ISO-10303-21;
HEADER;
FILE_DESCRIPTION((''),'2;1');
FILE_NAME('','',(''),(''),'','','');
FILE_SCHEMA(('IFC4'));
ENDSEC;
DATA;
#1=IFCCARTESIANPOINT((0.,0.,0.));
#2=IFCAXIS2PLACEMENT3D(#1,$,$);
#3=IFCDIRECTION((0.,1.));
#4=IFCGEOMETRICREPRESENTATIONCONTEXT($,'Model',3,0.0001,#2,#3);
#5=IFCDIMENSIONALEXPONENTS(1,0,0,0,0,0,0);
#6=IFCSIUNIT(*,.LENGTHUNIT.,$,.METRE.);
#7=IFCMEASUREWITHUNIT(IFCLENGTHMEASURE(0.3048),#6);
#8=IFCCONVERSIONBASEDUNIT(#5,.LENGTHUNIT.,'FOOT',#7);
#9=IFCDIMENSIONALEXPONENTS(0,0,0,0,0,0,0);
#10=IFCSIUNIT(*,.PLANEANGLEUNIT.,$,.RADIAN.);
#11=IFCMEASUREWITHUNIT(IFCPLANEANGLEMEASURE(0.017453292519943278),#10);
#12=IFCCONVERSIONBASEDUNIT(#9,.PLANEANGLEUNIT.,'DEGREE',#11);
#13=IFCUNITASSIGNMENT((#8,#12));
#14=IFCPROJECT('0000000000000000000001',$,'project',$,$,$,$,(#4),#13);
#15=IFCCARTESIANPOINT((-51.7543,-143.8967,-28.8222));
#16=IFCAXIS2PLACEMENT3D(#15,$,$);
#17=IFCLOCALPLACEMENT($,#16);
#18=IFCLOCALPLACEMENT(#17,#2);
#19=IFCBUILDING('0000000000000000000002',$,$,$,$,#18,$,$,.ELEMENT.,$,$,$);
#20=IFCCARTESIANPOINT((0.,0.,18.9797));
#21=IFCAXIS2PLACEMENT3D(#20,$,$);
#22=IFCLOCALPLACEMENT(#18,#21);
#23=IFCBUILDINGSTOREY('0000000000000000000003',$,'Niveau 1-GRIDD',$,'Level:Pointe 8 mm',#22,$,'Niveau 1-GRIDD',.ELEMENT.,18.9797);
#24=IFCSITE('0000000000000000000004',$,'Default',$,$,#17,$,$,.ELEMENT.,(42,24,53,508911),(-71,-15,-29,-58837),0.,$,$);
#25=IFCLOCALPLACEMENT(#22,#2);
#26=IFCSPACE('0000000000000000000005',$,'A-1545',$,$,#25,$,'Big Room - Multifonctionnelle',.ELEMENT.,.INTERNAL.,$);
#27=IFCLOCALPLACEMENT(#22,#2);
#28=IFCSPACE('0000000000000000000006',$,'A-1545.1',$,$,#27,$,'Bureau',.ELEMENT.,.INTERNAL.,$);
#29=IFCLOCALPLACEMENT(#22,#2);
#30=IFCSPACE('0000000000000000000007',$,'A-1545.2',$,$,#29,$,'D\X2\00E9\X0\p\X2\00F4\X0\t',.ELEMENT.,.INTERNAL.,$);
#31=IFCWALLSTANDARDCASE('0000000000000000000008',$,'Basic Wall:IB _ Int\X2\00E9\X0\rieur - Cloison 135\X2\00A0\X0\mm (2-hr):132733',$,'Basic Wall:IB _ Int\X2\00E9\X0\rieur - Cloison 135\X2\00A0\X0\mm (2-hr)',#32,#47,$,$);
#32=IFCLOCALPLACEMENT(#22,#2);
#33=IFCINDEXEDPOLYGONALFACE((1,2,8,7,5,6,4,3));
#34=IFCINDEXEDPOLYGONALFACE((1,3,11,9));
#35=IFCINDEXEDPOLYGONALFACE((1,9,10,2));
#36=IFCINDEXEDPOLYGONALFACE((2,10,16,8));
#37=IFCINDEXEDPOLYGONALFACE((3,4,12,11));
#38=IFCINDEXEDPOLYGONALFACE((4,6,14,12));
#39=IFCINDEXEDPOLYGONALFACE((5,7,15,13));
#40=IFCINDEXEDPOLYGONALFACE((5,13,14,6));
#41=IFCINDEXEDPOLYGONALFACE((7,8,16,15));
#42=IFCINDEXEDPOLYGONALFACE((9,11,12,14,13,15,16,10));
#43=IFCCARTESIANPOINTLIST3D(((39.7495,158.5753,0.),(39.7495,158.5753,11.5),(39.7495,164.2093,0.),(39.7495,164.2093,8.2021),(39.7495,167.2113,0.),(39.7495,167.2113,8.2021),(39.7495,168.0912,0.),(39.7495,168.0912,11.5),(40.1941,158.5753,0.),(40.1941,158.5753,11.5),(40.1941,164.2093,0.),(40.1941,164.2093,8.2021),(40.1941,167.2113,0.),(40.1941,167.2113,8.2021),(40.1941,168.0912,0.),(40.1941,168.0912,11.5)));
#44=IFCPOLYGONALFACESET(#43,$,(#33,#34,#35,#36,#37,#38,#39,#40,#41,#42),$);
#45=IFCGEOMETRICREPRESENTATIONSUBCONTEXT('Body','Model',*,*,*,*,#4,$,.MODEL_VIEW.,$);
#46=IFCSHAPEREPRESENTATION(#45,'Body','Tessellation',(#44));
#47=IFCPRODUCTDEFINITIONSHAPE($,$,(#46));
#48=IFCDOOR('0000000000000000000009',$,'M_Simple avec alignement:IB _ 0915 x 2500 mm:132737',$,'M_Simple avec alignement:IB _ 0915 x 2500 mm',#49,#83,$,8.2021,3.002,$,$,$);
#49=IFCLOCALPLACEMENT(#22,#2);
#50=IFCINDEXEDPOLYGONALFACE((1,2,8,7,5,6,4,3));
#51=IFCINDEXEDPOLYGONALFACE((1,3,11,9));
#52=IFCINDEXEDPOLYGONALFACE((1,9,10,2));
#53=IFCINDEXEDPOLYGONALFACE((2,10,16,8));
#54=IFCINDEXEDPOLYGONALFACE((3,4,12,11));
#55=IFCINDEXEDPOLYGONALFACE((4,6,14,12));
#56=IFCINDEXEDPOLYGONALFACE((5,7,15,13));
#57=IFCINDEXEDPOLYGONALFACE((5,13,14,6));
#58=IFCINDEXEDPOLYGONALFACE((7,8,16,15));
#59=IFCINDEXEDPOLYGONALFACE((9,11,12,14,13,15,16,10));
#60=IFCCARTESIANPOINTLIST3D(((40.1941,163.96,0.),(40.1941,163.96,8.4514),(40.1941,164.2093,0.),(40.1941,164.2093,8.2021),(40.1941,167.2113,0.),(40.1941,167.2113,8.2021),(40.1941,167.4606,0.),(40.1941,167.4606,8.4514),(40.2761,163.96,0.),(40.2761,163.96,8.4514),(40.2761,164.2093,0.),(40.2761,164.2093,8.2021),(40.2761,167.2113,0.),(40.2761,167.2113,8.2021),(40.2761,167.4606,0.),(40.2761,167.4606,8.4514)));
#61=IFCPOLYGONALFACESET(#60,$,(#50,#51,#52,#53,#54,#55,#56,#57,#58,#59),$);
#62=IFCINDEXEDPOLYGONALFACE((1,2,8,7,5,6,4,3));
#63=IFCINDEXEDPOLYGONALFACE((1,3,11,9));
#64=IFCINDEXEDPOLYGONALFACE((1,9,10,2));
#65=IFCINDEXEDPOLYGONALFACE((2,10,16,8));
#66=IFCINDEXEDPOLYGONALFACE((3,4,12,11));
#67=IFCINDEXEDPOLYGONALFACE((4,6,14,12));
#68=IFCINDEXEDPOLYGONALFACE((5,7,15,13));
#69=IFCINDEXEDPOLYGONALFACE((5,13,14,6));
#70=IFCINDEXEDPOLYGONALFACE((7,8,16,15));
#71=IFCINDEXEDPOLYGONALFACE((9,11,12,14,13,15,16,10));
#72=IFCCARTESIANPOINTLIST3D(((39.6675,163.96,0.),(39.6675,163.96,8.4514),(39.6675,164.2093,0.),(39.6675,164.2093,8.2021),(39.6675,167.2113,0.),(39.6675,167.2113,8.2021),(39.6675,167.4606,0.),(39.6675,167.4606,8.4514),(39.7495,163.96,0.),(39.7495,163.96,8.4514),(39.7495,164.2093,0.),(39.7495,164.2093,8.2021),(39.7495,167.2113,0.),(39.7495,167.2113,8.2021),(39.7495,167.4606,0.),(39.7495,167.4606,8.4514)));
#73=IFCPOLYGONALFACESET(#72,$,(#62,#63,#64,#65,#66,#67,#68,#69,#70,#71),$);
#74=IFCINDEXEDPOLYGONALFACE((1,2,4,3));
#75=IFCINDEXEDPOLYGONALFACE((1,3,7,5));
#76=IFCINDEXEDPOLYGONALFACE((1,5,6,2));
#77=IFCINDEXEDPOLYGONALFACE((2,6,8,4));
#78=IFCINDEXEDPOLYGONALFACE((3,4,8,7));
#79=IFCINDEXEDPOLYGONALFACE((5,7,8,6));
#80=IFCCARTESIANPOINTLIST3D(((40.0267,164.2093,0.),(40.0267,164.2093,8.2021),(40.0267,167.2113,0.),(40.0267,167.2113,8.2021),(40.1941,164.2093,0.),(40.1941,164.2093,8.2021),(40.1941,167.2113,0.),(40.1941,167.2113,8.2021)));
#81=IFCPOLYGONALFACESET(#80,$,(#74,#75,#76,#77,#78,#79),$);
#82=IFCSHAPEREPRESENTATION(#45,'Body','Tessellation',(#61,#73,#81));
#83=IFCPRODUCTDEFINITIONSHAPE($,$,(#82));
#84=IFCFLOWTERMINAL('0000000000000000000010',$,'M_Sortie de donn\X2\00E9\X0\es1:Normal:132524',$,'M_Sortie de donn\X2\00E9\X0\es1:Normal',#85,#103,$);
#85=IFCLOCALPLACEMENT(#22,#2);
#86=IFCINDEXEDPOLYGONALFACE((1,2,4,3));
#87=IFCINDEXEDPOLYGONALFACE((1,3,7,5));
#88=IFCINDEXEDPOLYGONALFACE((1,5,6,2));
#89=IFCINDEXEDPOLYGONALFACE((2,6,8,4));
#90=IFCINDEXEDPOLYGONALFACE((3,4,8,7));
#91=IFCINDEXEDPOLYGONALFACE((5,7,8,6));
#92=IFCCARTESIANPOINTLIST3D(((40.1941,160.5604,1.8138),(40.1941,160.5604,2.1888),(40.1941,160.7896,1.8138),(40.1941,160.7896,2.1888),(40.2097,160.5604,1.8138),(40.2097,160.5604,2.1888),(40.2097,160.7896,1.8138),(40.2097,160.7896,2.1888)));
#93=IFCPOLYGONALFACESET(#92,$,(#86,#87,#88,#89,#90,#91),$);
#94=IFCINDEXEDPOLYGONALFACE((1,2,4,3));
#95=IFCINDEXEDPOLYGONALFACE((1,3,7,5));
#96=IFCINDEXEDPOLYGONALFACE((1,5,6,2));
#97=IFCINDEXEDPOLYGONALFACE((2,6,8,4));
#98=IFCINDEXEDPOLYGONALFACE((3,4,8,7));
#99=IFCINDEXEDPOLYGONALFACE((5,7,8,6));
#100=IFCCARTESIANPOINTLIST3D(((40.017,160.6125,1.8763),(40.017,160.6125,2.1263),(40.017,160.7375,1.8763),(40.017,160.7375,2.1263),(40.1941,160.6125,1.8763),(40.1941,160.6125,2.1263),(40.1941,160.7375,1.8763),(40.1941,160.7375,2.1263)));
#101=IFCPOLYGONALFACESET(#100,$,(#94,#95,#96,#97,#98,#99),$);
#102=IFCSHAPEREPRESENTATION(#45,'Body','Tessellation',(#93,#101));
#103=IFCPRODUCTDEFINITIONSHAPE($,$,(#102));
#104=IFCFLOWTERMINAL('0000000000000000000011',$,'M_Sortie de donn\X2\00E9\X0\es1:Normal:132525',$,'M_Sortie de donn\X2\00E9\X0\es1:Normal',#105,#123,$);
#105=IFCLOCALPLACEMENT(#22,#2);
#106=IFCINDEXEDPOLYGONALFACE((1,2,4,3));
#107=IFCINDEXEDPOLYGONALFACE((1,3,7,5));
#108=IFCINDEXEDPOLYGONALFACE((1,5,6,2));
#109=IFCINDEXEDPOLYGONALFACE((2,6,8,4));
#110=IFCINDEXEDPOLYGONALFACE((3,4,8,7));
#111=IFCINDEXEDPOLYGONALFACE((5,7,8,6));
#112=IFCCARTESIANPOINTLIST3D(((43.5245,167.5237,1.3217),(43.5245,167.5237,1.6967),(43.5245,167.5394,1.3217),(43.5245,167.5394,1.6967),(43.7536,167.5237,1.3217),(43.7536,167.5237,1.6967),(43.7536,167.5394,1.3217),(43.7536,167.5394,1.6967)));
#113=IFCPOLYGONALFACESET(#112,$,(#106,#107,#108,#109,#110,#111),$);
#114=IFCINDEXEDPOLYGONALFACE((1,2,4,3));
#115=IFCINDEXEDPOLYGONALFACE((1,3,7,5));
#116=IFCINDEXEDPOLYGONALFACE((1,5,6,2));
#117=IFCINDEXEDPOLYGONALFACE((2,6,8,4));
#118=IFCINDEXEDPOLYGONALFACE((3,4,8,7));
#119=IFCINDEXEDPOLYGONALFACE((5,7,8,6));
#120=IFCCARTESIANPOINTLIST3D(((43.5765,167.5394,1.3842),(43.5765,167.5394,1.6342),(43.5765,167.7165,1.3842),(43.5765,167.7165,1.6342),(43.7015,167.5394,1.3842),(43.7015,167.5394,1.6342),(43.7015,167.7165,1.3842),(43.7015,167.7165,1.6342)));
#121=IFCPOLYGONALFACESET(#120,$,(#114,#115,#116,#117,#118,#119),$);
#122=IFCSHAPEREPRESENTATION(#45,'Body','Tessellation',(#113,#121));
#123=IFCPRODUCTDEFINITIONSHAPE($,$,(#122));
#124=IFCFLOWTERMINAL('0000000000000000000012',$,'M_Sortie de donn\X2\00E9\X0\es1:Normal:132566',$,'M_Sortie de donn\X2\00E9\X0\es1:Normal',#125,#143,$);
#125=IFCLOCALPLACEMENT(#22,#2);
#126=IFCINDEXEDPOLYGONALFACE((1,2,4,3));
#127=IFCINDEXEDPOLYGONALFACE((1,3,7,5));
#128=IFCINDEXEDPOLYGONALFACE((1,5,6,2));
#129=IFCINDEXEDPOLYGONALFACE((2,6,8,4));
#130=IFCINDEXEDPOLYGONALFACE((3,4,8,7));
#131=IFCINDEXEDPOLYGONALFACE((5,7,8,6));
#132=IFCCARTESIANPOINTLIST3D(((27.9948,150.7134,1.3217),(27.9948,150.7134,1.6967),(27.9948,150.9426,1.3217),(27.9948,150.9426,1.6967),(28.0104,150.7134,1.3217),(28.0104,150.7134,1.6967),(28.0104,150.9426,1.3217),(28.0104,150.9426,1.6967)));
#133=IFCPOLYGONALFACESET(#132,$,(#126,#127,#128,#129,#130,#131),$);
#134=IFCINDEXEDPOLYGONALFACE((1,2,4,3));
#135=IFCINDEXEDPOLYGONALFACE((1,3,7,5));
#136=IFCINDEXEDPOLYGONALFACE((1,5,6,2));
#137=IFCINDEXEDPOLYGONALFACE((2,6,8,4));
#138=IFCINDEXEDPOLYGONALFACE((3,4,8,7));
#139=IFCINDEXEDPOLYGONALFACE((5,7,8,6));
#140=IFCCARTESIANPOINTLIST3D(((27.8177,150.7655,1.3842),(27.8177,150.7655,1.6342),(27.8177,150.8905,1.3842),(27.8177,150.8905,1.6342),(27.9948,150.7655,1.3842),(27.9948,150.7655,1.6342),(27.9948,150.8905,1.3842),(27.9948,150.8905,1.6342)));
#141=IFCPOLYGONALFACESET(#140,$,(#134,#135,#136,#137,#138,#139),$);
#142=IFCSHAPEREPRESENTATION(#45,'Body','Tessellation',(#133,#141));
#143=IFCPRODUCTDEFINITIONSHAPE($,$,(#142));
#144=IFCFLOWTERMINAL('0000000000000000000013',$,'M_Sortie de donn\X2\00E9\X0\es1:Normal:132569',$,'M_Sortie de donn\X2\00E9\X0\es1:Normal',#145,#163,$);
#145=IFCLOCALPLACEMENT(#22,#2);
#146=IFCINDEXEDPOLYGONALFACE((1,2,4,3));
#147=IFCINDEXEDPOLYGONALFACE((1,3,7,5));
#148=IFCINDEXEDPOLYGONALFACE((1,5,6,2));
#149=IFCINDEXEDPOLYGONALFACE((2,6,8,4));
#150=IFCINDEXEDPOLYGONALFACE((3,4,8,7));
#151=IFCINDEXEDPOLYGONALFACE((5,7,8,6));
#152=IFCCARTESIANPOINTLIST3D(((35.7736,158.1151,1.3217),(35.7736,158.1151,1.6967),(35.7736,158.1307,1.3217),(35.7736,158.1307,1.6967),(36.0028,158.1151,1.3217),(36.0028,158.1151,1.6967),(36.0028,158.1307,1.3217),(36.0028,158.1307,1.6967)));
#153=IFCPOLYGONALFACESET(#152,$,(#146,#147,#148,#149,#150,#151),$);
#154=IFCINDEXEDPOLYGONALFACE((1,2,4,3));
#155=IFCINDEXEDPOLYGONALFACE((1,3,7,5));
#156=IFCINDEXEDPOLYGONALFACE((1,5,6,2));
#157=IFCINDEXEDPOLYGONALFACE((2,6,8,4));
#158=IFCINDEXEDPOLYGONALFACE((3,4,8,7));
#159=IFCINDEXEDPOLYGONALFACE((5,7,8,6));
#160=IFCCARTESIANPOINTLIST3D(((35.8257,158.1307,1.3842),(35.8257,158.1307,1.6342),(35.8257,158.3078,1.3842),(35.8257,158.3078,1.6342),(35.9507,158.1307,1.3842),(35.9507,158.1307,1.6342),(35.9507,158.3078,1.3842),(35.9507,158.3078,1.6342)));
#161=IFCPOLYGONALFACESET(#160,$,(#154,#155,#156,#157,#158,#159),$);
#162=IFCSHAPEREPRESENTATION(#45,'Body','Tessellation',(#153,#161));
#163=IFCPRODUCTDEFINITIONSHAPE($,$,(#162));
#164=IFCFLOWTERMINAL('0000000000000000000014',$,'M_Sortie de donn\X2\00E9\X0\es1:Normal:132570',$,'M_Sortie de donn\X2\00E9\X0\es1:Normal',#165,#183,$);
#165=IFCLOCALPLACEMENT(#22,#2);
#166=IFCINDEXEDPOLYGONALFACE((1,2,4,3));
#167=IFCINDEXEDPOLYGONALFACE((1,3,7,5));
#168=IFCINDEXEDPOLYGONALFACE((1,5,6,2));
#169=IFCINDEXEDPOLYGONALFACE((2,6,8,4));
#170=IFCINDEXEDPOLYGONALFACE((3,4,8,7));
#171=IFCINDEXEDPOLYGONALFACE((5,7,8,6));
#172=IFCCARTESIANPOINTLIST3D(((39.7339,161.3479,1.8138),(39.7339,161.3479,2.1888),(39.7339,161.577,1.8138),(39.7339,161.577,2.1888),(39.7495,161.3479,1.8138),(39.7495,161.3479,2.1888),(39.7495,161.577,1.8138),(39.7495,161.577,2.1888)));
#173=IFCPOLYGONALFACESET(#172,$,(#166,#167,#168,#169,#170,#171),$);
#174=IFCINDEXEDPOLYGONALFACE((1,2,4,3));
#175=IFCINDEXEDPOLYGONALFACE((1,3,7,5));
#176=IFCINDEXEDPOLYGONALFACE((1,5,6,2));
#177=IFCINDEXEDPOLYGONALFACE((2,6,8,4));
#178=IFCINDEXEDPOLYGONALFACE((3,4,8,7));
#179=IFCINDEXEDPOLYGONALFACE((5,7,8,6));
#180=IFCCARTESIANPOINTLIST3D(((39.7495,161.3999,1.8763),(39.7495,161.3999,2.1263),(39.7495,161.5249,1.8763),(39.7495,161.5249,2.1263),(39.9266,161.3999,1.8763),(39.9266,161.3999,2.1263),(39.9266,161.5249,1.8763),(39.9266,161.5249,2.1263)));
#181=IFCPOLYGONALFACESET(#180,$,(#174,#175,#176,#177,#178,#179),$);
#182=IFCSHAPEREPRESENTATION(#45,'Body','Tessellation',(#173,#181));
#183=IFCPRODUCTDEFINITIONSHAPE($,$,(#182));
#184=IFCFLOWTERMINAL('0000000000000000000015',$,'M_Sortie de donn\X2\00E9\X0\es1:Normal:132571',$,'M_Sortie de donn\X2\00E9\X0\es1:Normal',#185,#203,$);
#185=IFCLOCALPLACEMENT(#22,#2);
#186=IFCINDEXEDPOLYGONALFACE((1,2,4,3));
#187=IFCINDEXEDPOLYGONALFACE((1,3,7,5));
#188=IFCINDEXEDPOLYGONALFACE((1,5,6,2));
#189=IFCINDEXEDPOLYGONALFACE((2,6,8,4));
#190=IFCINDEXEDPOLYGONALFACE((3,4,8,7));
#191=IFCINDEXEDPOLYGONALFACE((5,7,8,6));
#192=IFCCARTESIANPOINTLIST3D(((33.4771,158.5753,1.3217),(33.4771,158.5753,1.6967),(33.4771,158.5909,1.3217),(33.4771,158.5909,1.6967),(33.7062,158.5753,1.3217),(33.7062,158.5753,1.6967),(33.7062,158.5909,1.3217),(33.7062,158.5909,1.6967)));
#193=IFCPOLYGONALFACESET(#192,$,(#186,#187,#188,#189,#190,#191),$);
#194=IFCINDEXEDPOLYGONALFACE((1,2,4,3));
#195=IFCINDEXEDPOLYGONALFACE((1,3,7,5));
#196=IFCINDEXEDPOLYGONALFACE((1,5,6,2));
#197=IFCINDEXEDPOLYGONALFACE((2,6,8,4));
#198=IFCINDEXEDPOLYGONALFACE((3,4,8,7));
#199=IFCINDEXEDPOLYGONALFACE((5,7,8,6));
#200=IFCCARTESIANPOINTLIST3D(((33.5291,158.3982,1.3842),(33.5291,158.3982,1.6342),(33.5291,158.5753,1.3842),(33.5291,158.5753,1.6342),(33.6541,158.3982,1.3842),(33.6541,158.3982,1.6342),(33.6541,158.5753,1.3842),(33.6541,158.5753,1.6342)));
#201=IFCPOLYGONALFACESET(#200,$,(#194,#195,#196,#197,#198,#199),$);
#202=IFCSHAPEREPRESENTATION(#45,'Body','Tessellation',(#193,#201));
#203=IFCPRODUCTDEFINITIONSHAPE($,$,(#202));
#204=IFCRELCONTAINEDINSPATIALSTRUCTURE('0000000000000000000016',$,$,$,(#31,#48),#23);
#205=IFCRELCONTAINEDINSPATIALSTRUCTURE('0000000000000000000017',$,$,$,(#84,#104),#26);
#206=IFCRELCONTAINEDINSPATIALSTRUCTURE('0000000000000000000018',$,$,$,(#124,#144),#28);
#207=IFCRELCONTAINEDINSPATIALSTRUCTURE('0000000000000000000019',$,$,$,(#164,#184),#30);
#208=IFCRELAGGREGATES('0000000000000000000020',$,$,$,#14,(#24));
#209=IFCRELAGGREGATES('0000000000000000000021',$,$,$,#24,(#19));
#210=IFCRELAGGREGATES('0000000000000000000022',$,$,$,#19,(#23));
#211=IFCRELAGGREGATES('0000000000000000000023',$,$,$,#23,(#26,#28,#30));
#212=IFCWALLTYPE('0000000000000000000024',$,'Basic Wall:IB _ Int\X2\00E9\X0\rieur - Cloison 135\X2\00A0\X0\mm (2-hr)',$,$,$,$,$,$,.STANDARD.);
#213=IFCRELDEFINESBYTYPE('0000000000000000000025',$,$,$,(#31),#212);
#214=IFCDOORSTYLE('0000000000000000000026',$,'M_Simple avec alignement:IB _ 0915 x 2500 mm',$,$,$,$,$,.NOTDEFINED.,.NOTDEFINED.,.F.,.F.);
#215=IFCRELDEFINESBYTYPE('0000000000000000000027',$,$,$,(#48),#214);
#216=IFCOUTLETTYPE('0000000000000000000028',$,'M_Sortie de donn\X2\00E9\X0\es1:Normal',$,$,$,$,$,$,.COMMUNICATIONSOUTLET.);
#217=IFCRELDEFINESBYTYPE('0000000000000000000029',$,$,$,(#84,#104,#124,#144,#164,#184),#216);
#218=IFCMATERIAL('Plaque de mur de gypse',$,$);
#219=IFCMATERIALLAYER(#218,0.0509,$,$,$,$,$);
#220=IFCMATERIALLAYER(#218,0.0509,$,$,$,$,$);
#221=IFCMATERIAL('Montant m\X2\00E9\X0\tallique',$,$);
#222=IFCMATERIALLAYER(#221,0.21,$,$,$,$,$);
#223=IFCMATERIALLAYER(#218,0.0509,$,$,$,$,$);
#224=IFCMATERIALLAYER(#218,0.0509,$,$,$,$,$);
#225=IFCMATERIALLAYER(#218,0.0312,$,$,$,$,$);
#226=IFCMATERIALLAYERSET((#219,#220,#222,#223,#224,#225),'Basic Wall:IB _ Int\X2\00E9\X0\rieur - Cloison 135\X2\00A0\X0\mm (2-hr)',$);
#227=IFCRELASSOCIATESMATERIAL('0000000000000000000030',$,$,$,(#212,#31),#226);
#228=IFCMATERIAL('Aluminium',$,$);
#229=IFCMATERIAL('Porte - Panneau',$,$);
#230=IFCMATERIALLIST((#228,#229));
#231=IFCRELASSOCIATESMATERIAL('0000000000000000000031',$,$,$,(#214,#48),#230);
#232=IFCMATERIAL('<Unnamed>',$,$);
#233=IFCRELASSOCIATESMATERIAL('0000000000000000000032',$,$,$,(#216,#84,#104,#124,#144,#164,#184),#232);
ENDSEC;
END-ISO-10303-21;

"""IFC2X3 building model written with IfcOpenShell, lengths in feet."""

from ifc_helpers import new_model, entity, si_unit, converted_unit, direction, frame, frame_2d, origin, place, context, subcontext, project, spatial, polyline, rectangle, outline, extrude, source, transform, mapped, material, material_list, layer, layer_set, layer_usage, type_object, type_shapes, element, fill, save


model = new_model("IFC2X3")

# Units and contexts
model_context = context("Model", 3, precision=0.0001, world=origin(), true_north=direction((0.0, 1.0)))
body_context = subcontext(model_context, "Body", "Model", "MODEL_VIEW")
ifc_project = project(units=[converted_unit("LENGTHUNIT", "FOOT", entity("IfcLengthMeasure", 0.3048), si_unit("LENGTHUNIT", "METRE"), dimensions=[1, 0, 0, 0, 0, 0, 0]), converted_unit("PLANEANGLEUNIT", "DEGREE", entity("IfcPlaneAngleMeasure", 0.017453292519943278), si_unit("PLANEANGLEUNIT", "RADIAN"), dimensions=[0, 0, 0, 0, 0, 0, 0])], contexts=[model_context])

# Site, building, storey
site_placement = place(None, frame((-51.7543, -143.8967, -28.8222)))
site = spatial("IfcSite", under=ifc_project, at=site_placement, Name="Default", CompositionType="ELEMENT", RefLatitude=(42, 24, 53, 508911), RefLongitude=(-71, -15, -29, -58837), RefElevation=0.0)
building_placement = place(site_placement, origin())
building = spatial("IfcBuilding", under=site, at=building_placement, CompositionType="ELEMENT")
storey_placement = place(building_placement, frame((0.0, 0.0, 18.9797)))
storey = spatial("IfcBuildingStorey", under=building, at=storey_placement, Name="Niveau 1-GRIDD", ObjectType="Level:Pointe 8 mm", LongName="Niveau 1-GRIDD", CompositionType="ELEMENT", Elevation=18.9797)

# Shared definitions
ifc_material_1 = material(Name="Plaque de mur de gypse")
ifc_material_2 = material(Name="Montant métallique")
ifc_layer_1 = layer(ifc_material_1, 0.0509)
ifc_layer_2 = layer(ifc_material_1, 0.0509)
ifc_layer_3 = layer(ifc_material_2, 0.21)
ifc_layer_4 = layer(ifc_material_1, 0.0509)
ifc_layer_5 = layer(ifc_material_1, 0.0509)
ifc_layer_6 = layer(ifc_material_1, 0.0312)
ifc_layer_set_1 = layer_set([ifc_layer_1, ifc_layer_2, ifc_layer_3, ifc_layer_4, ifc_layer_5, ifc_layer_6], Name="Basic Wall:IB _ Intérieur - Cloison 135 mm (2-hr)")
wall_type_1 = type_object("IfcWallType", Name="Basic Wall:IB _ Intérieur - Cloison 135 mm (2-hr)", PredefinedType="STANDARD", material=ifc_layer_set_1)

# Shared definitions
ifc_material_3 = material(Name="Aluminium")
ifc_material_4 = material(Name="Porte - Panneau")
ifc_material_list_1 = material_list([ifc_material_3, ifc_material_4])
door_style = type_object("IfcDoorStyle", Name="M_Simple avec alignement:IB _ 0915 x 2500 mm", ConstructionType="NOTDEFINED", OperationType="NOTDEFINED", ParameterTakesPrecedence=False, Sizeable=False, material=ifc_material_list_1)
shared_shape_1 = source(origin(), body_context, "Body", "SweptSolid", [
    extrude(outline(polyline([(-1.7503, -4.2881), (1.7503, -4.2881), (1.7503, 4.1634), (1.501, 4.1634), (1.501, -4.0387), (-1.501, -4.0387), (-1.501, 4.1634), (-1.7503, 4.1634), (-1.7503, -4.2881)])), frame((1.501, 0.4446, 4.1634), z_axis=(0.0, 1.0, 0.0), x_axis=(1.0, 0.0, 0.0)), (0.0, 0.0, 1.0), 0.082),
    extrude(outline(polyline([(-4.2881, -1.7503), (4.1634, -1.7503), (4.1634, -1.501), (-4.0387, -1.501), (-4.0387, 1.501), (4.1634, 1.501), (4.1634, 1.7503), (-4.2881, 1.7503), (-4.2881, -1.7503)])), frame((1.501, -0.082, 4.1634), z_axis=(0.0, 1.0, 0.0), x_axis=(0.0, 0.0, -1.0)), (0.0, 0.0, 1.0), 0.082),
    extrude(rectangle(XDim=0.1673, YDim=3.002, at=frame_2d((0.0, 0.0), x_axis=(1.0, 0.0))), frame((1.501, 0.3609, 0.0), z_axis=(0.0, 0.0, 1.0), x_axis=(0.0, 1.0, 0.0)), (0.0, 0.0, 1.0), 8.2021),
])
type_shapes(door_style, [shared_shape_1])

# Wall, opening, door
ifc_layer_usage_1 = layer_usage(ifc_layer_set_1, "AXIS2", "NEGATIVE", 0.2223)
wall_1_placement = place(storey_placement, frame((39.9718, 158.5753, 0.0), z_axis=(0.0, 0.0, 1.0), x_axis=(0.0, 1.0, 0.0)))
wall_1 = element("IfcWallStandardCase", 1, at=wall_1_placement, inside=storey, type_object=wall_type_1, material=ifc_layer_usage_1, Name="Basic Wall:IB _ Intérieur - Cloison 135 mm (2-hr):132733", ObjectType="Basic Wall:IB _ Intérieur - Cloison 135 mm (2-hr)", context=body_context, shape_type="SweptSolid", body=[
    extrude(rectangle(XDim=9.5159, YDim=0.4446, at=frame_2d((4.758, 0.0), x_axis=(1.0, 0.0))), origin(), (0.0, 0.0, 1.0), 11.5),
])
opening_1_placement = place(wall_1_placement, frame((8.636, 0.2223, 0.0)))
opening_1 = element("IfcOpeningElement", 2, at=opening_1_placement, cuts=wall_1, ObjectType="Opening", context=body_context, shape_type="SweptSolid", body=[
    extrude(rectangle(XDim=3.002, YDim=8.2021, at=frame_2d((4.101, 1.501), x_axis=(0.0, 1.0))), frame((0.0, 0.0, 0.0), z_axis=(0.0, -1.0, 0.0), x_axis=(0.0, 0.0, 1.0)), (0.0, 0.0, 1.0), 0.4446),
])
door_1_placement = place(opening_1_placement, frame((0.0, 0.0, 0.0), z_axis=(0.0, 0.0, 1.0), x_axis=(-1.0, 0.0, 0.0)))
door_1 = element("IfcDoor", 3, at=door_1_placement, inside=storey, type_object=door_style, material=ifc_material_list_1, Name="M_Simple avec alignement:IB _ 0915 x 2500 mm:132737", ObjectType="M_Simple avec alignement:IB _ 0915 x 2500 mm", OverallHeight=8.2021, OverallWidth=3.002, context=body_context, shape_type="MappedRepresentation", body=[
    mapped(shared_shape_1, transform((0.0, 0.0, 0.0), scale=1.0)),
])
fill(opening_1, door_1)

# Shared definitions
space_1_placement = place(storey_placement, origin())
space_1 = spatial("IfcSpace", under=storey, at=space_1_placement, Name="A-1545", LongName="Big Room - Multifonctionnelle", CompositionType="ELEMENT", InteriorOrExteriorSpace="INTERNAL")

# Flow terminals
ifc_material_5 = material(Name="<Unnamed>")
outlet_type = type_object("IfcOutletType", Name="M_Sortie de données1:Normal", PredefinedType="COMMUNICATIONSOUTLET", material=ifc_material_5)
shared_shape_2 = source(origin(), body_context, "Body", "SweptSolid", [
    extrude(rectangle(XDim=0.2292, YDim=0.375, at=frame_2d((0.0, 0.0), x_axis=(1.0, 0.0))), frame((0.0, 0.0, 0.0), z_axis=(0.0, 0.0, 1.0), x_axis=(-1.0, 0.0, 0.0)), (0.0, 0.0, 1.0), 0.0156),
    extrude(rectangle(XDim=0.125, YDim=0.25, at=frame_2d((0.0, 0.0), x_axis=(1.0, 0.0))), frame((0.0, 0.0, -0.1771), z_axis=(0.0, 0.0, 1.0), x_axis=(-1.0, 0.0, 0.0)), (0.0, 0.0, 1.0), 0.1771),
])
type_shapes(outlet_type, [shared_shape_2])
for number, where, z_axis, x_axis, name in (
    (4, (40.1941, 160.675, 2.0013), (1.0, 0.0, 0.0), (0.0, 1.0, 0.0), "M_Sortie de données1:Normal:132524"),
    (5, (43.639, 167.5394, 1.5092), (0.0, -1.0, 0.0), (1.0, 0.0, 0.0), "M_Sortie de données1:Normal:132525"),
):
    element("IfcFlowTerminal", number, at=place(space_1_placement, frame(where, z_axis=z_axis, x_axis=x_axis)), inside=space_1, type_object=outlet_type, material=ifc_material_5, Name=name, ObjectType="M_Sortie de données1:Normal", context=body_context, shape_type="MappedRepresentation", body=[
        mapped(shared_shape_2, transform((0.0, 0.0, 0.0), scale=1.0)),
    ])

# Shared definitions
space_2_placement = place(storey_placement, origin())
space_2 = spatial("IfcSpace", under=storey, at=space_2_placement, Name="A-1545.1", LongName="Bureau", CompositionType="ELEMENT", InteriorOrExteriorSpace="INTERNAL")

# Flow terminals
for number, where, z_axis, x_axis, name in (
    (6, (27.9948, 150.828, 1.5092), (1.0, 0.0, 0.0), (0.0, 1.0, 0.0), "M_Sortie de données1:Normal:132566"),
    (7, (35.8882, 158.1307, 1.5092), (0.0, -1.0, 0.0), (1.0, 0.0, 0.0), "M_Sortie de données1:Normal:132569"),
):
    element("IfcFlowTerminal", number, at=place(space_2_placement, frame(where, z_axis=z_axis, x_axis=x_axis)), inside=space_2, type_object=outlet_type, material=ifc_material_5, Name=name, ObjectType="M_Sortie de données1:Normal", context=body_context, shape_type="MappedRepresentation", body=[
        mapped(shared_shape_2, transform((0.0, 0.0, 0.0), scale=1.0)),
    ])

# Shared definitions
space_3_placement = place(storey_placement, origin())
space_3 = spatial("IfcSpace", under=storey, at=space_3_placement, Name="A-1545.2", LongName="Dépôt", CompositionType="ELEMENT", InteriorOrExteriorSpace="INTERNAL")

# Flow terminals
for number, where, z_axis, x_axis, name in (
    (8, (39.7495, 161.4624, 2.0013), (-1.0, 0.0, 0.0), (0.0, -1.0, 0.0), "M_Sortie de données1:Normal:132570"),
    (9, (33.5916, 158.5753, 1.5092), (0.0, 1.0, 0.0), (-1.0, 0.0, 0.0), "M_Sortie de données1:Normal:132571"),
):
    element("IfcFlowTerminal", number, at=place(space_3_placement, frame(where, z_axis=z_axis, x_axis=x_axis)), inside=space_3, type_object=outlet_type, material=ifc_material_5, Name=name, ObjectType="M_Sortie de données1:Normal", context=body_context, shape_type="MappedRepresentation", body=[
        mapped(shared_shape_2, transform((0.0, 0.0, 0.0), scale=1.0)),
    ])

save(model, "model.ifc")
